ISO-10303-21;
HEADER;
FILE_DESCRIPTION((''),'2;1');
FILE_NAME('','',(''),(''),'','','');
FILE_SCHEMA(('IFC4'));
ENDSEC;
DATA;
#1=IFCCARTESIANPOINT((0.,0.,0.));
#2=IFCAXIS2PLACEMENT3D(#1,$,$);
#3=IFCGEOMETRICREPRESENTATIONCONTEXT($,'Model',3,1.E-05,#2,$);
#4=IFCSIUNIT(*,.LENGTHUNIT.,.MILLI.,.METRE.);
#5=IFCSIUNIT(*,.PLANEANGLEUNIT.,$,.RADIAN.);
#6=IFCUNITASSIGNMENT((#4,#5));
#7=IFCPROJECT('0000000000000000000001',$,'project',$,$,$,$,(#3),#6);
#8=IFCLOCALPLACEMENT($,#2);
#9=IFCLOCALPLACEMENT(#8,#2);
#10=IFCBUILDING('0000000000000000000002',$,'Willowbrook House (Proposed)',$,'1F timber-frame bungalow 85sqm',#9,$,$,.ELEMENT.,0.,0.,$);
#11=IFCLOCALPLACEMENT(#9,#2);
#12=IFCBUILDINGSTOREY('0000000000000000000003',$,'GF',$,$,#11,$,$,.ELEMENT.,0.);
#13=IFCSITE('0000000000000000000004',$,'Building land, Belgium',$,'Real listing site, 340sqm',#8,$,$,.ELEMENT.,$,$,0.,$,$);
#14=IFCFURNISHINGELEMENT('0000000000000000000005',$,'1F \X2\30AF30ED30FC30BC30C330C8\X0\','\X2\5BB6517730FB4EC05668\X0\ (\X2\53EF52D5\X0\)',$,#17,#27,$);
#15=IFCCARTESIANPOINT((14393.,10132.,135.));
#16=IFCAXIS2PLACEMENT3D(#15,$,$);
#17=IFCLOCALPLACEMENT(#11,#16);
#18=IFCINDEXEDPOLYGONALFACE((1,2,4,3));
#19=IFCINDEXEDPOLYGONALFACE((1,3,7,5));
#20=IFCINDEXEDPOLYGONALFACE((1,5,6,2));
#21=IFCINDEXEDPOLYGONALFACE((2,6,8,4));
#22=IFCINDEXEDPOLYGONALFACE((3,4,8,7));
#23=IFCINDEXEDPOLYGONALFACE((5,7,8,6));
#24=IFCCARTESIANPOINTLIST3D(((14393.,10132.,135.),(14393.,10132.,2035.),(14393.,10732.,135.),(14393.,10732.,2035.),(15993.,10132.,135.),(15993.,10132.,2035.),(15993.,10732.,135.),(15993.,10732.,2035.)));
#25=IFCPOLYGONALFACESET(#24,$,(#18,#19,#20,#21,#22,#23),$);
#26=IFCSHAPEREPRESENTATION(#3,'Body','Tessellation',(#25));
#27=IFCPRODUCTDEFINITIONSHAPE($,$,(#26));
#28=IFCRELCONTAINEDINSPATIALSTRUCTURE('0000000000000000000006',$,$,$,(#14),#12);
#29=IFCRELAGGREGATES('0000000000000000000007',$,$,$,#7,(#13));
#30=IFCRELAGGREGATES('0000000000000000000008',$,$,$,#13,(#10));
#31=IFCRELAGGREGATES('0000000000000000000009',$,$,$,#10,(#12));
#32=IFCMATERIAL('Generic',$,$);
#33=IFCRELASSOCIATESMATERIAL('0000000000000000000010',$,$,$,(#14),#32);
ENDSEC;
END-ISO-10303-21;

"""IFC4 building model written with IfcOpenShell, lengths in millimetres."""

from ifc_helpers import new_model, si_unit, frame, frame_2d, origin, place, context, project, spatial, rectangle, extrude, material, element, save


model = new_model("IFC4")

# Units and contexts
model_context = context("Model", 3, precision=1e-05, world=origin())
ifc_project = project(units=[si_unit("LENGTHUNIT", "METRE", prefix="MILLI"), si_unit("PLANEANGLEUNIT", "RADIAN")], contexts=[model_context])

# Site, building, storey
site_placement = place(None, origin())
site = spatial("IfcSite", under=ifc_project, at=site_placement, Name="Building land, Belgium", ObjectType="Real listing site, 340sqm", CompositionType="ELEMENT", RefElevation=0.0)
building_placement = place(site_placement, origin())
building = spatial("IfcBuilding", under=site, at=building_placement, Name="Willowbrook House (Proposed)", ObjectType="1F timber-frame bungalow 85sqm", CompositionType="ELEMENT", ElevationOfRefHeight=0.0, ElevationOfTerrain=0.0)
storey_placement = place(building_placement, origin())
storey = spatial("IfcBuildingStorey", under=building, at=storey_placement, Name="GF", CompositionType="ELEMENT", Elevation=0.0)

# Shared definitions
ifc_material_1 = material(Name="Generic")

# Furnishing element
furnishing_placement = place(storey_placement, frame((14393.0, 10132.0, 135.0)))
element("IfcFurnishingElement", 1, at=furnishing_placement, inside=storey, material=ifc_material_1, Name="1F クローゼット", Description="家具・什器 (可動)", context=model_context, shape_type="SweptSolid", body=[
    extrude(rectangle(XDim=1600.0, YDim=600.0, at=frame_2d((800.0, 300.0))), frame((14393.0, 10132.0, 135.0)), (0.0, 0.0, 1.0), 1900.0),
])

save(model, "model.ifc")
